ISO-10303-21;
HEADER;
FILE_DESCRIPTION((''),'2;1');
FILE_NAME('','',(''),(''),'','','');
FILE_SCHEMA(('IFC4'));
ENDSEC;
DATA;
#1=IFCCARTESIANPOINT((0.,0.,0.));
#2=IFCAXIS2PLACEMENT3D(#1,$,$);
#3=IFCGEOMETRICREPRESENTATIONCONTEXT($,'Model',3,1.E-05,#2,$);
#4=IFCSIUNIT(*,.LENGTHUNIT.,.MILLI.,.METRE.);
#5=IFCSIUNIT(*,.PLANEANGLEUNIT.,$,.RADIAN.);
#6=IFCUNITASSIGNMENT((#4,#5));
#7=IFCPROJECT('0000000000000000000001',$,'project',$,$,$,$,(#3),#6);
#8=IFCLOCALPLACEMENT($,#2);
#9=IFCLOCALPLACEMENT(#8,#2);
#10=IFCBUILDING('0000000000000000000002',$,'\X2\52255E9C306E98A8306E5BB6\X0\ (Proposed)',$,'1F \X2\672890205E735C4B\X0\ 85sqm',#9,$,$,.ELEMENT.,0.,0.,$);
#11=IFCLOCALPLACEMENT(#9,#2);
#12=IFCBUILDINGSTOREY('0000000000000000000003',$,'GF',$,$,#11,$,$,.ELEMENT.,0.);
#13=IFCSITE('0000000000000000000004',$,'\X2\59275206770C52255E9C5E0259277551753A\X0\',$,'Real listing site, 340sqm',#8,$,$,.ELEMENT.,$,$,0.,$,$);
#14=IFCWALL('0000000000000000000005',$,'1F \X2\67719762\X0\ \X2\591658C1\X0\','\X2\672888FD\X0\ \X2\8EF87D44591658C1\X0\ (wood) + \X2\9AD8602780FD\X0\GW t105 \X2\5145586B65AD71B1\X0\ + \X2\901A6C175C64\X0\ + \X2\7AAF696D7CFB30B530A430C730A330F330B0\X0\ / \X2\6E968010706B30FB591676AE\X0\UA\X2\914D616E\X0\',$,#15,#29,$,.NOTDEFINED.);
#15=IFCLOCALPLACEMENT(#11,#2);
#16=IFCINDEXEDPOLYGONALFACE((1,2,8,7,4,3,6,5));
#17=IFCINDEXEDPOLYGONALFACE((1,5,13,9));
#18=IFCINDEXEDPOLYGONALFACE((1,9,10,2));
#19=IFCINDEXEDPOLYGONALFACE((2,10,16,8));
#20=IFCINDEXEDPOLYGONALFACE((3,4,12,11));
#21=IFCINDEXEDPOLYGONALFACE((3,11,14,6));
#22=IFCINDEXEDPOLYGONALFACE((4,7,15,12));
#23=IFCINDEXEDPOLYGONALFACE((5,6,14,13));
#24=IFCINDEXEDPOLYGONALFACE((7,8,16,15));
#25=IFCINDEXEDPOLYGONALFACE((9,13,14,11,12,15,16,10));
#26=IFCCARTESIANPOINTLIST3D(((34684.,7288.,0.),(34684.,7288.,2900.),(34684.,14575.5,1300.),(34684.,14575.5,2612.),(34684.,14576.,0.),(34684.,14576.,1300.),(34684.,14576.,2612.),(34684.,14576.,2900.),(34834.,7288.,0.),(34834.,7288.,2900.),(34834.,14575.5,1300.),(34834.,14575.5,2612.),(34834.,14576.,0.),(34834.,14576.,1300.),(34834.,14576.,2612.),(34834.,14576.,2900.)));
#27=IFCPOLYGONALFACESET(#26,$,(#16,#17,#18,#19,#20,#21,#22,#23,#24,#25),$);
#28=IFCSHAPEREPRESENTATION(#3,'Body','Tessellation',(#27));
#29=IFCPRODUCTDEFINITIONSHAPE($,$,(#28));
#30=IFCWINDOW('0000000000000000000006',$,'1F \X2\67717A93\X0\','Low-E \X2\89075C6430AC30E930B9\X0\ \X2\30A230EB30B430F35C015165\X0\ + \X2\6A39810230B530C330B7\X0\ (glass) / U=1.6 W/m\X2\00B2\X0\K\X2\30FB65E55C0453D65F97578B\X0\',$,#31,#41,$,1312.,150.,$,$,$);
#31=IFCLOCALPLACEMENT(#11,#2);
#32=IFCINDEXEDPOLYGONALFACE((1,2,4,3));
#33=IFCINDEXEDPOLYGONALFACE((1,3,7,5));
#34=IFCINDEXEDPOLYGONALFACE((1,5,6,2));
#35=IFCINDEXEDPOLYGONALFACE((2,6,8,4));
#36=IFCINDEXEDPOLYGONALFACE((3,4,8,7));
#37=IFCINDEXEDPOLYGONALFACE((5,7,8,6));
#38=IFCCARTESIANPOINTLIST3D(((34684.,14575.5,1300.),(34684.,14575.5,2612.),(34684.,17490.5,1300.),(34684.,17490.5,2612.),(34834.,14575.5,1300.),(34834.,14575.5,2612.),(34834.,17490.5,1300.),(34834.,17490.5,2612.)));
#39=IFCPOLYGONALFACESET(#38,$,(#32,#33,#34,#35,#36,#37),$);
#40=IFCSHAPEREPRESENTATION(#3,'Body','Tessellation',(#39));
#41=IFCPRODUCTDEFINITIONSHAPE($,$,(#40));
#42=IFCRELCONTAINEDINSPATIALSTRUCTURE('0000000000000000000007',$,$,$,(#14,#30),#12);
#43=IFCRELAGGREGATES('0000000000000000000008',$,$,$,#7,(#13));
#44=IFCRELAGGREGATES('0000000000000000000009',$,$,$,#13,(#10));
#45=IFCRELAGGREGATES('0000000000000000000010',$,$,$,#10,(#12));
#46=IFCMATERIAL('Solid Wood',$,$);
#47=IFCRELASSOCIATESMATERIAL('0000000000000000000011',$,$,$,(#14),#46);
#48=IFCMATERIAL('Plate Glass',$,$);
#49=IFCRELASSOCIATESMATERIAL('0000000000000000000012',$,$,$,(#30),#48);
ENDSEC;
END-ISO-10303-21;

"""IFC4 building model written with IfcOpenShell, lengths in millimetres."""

from ifc_helpers import new_model, si_unit, frame, frame_2d, origin, place, context, project, spatial, rectangle, extrude, material, element, fill, save


model = new_model("IFC4")

# Units and contexts
model_context = context("Model", 3, precision=1e-05, world=origin())
ifc_project = project(units=[si_unit("LENGTHUNIT", "METRE", prefix="MILLI"), si_unit("PLANEANGLEUNIT", "RADIAN")], contexts=[model_context])

# Site, building, storey
site_placement = place(None, origin())
site = spatial("IfcSite", under=ifc_project, at=site_placement, Name="大分県別府市大畑町", ObjectType="Real listing site, 340sqm", CompositionType="ELEMENT", RefElevation=0.0)
building_placement = place(site_placement, origin())
building = spatial("IfcBuilding", under=site, at=building_placement, Name="別府の風の家 (Proposed)", ObjectType="1F 木造平屋 85sqm", CompositionType="ELEMENT", ElevationOfRefHeight=0.0, ElevationOfTerrain=0.0)
storey_placement = place(building_placement, origin())
storey = spatial("IfcBuildingStorey", under=building, at=storey_placement, Name="GF", CompositionType="ELEMENT", Elevation=0.0)

# Shared definitions
ifc_material_1 = material(Name="Solid Wood")

# Wall, opening, window
wall_1_placement = place(storey_placement, frame((17342.0, 3644.0, 0.0)))
wall_1 = element("IfcWall", 1, at=wall_1_placement, inside=storey, material=ifc_material_1, Name="1F 東面 外壁", Description="木製 軸組外壁 (wood) + 高性能GW t105 充填断熱 + 通気層 + 窯業系サイディング / 準耐火・外皮UA配慮", PredefinedType="NOTDEFINED", context=model_context, shape_type="SweptSolid", body=[
    extrude(rectangle(XDim=150.0, YDim=7288.0, at=frame_2d((75.0, 3644.0))), frame((17342.0, 3644.0, 0.0)), (0.0, 0.0, 1.0), 2900.0),
])
opening_placement = place(storey_placement, frame((17342.0, 7288.0, 650.0)))
opening = element("IfcOpeningElement", 2, at=opening_placement, cuts=wall_1, PredefinedType="NOTDEFINED", context=model_context, shape_type="SweptSolid", body=[
    extrude(rectangle(XDim=150.0, YDim=2915.0, at=frame_2d((75.0, 1457.0))), frame((17342.0, 7288.0, 650.0)), (0.0, 0.0, 1.0), 1312.0),
])
ifc_material_2 = material(Name="Plate Glass")
window_1_placement = place(storey_placement, frame((17342.0, 7288.0, 650.0)))
window_1 = element("IfcWindow", 3, at=window_1_placement, inside=storey, material=ifc_material_2, Name="1F 東窓", Description="Low-E 複層ガラス アルゴン封入 + 樹脂サッシ (glass) / U=1.6 W/m²K・日射取得型", OverallHeight=1312.0, OverallWidth=150.0, context=model_context, shape_type="SweptSolid", body=[
    extrude(rectangle(XDim=150.0, YDim=2915.0, at=frame_2d((75.0, 1457.0))), frame((17342.0, 7288.0, 650.0)), (0.0, 0.0, 1.0), 1312.0),
])
fill(opening, window_1)

save(model, "model.ifc")
